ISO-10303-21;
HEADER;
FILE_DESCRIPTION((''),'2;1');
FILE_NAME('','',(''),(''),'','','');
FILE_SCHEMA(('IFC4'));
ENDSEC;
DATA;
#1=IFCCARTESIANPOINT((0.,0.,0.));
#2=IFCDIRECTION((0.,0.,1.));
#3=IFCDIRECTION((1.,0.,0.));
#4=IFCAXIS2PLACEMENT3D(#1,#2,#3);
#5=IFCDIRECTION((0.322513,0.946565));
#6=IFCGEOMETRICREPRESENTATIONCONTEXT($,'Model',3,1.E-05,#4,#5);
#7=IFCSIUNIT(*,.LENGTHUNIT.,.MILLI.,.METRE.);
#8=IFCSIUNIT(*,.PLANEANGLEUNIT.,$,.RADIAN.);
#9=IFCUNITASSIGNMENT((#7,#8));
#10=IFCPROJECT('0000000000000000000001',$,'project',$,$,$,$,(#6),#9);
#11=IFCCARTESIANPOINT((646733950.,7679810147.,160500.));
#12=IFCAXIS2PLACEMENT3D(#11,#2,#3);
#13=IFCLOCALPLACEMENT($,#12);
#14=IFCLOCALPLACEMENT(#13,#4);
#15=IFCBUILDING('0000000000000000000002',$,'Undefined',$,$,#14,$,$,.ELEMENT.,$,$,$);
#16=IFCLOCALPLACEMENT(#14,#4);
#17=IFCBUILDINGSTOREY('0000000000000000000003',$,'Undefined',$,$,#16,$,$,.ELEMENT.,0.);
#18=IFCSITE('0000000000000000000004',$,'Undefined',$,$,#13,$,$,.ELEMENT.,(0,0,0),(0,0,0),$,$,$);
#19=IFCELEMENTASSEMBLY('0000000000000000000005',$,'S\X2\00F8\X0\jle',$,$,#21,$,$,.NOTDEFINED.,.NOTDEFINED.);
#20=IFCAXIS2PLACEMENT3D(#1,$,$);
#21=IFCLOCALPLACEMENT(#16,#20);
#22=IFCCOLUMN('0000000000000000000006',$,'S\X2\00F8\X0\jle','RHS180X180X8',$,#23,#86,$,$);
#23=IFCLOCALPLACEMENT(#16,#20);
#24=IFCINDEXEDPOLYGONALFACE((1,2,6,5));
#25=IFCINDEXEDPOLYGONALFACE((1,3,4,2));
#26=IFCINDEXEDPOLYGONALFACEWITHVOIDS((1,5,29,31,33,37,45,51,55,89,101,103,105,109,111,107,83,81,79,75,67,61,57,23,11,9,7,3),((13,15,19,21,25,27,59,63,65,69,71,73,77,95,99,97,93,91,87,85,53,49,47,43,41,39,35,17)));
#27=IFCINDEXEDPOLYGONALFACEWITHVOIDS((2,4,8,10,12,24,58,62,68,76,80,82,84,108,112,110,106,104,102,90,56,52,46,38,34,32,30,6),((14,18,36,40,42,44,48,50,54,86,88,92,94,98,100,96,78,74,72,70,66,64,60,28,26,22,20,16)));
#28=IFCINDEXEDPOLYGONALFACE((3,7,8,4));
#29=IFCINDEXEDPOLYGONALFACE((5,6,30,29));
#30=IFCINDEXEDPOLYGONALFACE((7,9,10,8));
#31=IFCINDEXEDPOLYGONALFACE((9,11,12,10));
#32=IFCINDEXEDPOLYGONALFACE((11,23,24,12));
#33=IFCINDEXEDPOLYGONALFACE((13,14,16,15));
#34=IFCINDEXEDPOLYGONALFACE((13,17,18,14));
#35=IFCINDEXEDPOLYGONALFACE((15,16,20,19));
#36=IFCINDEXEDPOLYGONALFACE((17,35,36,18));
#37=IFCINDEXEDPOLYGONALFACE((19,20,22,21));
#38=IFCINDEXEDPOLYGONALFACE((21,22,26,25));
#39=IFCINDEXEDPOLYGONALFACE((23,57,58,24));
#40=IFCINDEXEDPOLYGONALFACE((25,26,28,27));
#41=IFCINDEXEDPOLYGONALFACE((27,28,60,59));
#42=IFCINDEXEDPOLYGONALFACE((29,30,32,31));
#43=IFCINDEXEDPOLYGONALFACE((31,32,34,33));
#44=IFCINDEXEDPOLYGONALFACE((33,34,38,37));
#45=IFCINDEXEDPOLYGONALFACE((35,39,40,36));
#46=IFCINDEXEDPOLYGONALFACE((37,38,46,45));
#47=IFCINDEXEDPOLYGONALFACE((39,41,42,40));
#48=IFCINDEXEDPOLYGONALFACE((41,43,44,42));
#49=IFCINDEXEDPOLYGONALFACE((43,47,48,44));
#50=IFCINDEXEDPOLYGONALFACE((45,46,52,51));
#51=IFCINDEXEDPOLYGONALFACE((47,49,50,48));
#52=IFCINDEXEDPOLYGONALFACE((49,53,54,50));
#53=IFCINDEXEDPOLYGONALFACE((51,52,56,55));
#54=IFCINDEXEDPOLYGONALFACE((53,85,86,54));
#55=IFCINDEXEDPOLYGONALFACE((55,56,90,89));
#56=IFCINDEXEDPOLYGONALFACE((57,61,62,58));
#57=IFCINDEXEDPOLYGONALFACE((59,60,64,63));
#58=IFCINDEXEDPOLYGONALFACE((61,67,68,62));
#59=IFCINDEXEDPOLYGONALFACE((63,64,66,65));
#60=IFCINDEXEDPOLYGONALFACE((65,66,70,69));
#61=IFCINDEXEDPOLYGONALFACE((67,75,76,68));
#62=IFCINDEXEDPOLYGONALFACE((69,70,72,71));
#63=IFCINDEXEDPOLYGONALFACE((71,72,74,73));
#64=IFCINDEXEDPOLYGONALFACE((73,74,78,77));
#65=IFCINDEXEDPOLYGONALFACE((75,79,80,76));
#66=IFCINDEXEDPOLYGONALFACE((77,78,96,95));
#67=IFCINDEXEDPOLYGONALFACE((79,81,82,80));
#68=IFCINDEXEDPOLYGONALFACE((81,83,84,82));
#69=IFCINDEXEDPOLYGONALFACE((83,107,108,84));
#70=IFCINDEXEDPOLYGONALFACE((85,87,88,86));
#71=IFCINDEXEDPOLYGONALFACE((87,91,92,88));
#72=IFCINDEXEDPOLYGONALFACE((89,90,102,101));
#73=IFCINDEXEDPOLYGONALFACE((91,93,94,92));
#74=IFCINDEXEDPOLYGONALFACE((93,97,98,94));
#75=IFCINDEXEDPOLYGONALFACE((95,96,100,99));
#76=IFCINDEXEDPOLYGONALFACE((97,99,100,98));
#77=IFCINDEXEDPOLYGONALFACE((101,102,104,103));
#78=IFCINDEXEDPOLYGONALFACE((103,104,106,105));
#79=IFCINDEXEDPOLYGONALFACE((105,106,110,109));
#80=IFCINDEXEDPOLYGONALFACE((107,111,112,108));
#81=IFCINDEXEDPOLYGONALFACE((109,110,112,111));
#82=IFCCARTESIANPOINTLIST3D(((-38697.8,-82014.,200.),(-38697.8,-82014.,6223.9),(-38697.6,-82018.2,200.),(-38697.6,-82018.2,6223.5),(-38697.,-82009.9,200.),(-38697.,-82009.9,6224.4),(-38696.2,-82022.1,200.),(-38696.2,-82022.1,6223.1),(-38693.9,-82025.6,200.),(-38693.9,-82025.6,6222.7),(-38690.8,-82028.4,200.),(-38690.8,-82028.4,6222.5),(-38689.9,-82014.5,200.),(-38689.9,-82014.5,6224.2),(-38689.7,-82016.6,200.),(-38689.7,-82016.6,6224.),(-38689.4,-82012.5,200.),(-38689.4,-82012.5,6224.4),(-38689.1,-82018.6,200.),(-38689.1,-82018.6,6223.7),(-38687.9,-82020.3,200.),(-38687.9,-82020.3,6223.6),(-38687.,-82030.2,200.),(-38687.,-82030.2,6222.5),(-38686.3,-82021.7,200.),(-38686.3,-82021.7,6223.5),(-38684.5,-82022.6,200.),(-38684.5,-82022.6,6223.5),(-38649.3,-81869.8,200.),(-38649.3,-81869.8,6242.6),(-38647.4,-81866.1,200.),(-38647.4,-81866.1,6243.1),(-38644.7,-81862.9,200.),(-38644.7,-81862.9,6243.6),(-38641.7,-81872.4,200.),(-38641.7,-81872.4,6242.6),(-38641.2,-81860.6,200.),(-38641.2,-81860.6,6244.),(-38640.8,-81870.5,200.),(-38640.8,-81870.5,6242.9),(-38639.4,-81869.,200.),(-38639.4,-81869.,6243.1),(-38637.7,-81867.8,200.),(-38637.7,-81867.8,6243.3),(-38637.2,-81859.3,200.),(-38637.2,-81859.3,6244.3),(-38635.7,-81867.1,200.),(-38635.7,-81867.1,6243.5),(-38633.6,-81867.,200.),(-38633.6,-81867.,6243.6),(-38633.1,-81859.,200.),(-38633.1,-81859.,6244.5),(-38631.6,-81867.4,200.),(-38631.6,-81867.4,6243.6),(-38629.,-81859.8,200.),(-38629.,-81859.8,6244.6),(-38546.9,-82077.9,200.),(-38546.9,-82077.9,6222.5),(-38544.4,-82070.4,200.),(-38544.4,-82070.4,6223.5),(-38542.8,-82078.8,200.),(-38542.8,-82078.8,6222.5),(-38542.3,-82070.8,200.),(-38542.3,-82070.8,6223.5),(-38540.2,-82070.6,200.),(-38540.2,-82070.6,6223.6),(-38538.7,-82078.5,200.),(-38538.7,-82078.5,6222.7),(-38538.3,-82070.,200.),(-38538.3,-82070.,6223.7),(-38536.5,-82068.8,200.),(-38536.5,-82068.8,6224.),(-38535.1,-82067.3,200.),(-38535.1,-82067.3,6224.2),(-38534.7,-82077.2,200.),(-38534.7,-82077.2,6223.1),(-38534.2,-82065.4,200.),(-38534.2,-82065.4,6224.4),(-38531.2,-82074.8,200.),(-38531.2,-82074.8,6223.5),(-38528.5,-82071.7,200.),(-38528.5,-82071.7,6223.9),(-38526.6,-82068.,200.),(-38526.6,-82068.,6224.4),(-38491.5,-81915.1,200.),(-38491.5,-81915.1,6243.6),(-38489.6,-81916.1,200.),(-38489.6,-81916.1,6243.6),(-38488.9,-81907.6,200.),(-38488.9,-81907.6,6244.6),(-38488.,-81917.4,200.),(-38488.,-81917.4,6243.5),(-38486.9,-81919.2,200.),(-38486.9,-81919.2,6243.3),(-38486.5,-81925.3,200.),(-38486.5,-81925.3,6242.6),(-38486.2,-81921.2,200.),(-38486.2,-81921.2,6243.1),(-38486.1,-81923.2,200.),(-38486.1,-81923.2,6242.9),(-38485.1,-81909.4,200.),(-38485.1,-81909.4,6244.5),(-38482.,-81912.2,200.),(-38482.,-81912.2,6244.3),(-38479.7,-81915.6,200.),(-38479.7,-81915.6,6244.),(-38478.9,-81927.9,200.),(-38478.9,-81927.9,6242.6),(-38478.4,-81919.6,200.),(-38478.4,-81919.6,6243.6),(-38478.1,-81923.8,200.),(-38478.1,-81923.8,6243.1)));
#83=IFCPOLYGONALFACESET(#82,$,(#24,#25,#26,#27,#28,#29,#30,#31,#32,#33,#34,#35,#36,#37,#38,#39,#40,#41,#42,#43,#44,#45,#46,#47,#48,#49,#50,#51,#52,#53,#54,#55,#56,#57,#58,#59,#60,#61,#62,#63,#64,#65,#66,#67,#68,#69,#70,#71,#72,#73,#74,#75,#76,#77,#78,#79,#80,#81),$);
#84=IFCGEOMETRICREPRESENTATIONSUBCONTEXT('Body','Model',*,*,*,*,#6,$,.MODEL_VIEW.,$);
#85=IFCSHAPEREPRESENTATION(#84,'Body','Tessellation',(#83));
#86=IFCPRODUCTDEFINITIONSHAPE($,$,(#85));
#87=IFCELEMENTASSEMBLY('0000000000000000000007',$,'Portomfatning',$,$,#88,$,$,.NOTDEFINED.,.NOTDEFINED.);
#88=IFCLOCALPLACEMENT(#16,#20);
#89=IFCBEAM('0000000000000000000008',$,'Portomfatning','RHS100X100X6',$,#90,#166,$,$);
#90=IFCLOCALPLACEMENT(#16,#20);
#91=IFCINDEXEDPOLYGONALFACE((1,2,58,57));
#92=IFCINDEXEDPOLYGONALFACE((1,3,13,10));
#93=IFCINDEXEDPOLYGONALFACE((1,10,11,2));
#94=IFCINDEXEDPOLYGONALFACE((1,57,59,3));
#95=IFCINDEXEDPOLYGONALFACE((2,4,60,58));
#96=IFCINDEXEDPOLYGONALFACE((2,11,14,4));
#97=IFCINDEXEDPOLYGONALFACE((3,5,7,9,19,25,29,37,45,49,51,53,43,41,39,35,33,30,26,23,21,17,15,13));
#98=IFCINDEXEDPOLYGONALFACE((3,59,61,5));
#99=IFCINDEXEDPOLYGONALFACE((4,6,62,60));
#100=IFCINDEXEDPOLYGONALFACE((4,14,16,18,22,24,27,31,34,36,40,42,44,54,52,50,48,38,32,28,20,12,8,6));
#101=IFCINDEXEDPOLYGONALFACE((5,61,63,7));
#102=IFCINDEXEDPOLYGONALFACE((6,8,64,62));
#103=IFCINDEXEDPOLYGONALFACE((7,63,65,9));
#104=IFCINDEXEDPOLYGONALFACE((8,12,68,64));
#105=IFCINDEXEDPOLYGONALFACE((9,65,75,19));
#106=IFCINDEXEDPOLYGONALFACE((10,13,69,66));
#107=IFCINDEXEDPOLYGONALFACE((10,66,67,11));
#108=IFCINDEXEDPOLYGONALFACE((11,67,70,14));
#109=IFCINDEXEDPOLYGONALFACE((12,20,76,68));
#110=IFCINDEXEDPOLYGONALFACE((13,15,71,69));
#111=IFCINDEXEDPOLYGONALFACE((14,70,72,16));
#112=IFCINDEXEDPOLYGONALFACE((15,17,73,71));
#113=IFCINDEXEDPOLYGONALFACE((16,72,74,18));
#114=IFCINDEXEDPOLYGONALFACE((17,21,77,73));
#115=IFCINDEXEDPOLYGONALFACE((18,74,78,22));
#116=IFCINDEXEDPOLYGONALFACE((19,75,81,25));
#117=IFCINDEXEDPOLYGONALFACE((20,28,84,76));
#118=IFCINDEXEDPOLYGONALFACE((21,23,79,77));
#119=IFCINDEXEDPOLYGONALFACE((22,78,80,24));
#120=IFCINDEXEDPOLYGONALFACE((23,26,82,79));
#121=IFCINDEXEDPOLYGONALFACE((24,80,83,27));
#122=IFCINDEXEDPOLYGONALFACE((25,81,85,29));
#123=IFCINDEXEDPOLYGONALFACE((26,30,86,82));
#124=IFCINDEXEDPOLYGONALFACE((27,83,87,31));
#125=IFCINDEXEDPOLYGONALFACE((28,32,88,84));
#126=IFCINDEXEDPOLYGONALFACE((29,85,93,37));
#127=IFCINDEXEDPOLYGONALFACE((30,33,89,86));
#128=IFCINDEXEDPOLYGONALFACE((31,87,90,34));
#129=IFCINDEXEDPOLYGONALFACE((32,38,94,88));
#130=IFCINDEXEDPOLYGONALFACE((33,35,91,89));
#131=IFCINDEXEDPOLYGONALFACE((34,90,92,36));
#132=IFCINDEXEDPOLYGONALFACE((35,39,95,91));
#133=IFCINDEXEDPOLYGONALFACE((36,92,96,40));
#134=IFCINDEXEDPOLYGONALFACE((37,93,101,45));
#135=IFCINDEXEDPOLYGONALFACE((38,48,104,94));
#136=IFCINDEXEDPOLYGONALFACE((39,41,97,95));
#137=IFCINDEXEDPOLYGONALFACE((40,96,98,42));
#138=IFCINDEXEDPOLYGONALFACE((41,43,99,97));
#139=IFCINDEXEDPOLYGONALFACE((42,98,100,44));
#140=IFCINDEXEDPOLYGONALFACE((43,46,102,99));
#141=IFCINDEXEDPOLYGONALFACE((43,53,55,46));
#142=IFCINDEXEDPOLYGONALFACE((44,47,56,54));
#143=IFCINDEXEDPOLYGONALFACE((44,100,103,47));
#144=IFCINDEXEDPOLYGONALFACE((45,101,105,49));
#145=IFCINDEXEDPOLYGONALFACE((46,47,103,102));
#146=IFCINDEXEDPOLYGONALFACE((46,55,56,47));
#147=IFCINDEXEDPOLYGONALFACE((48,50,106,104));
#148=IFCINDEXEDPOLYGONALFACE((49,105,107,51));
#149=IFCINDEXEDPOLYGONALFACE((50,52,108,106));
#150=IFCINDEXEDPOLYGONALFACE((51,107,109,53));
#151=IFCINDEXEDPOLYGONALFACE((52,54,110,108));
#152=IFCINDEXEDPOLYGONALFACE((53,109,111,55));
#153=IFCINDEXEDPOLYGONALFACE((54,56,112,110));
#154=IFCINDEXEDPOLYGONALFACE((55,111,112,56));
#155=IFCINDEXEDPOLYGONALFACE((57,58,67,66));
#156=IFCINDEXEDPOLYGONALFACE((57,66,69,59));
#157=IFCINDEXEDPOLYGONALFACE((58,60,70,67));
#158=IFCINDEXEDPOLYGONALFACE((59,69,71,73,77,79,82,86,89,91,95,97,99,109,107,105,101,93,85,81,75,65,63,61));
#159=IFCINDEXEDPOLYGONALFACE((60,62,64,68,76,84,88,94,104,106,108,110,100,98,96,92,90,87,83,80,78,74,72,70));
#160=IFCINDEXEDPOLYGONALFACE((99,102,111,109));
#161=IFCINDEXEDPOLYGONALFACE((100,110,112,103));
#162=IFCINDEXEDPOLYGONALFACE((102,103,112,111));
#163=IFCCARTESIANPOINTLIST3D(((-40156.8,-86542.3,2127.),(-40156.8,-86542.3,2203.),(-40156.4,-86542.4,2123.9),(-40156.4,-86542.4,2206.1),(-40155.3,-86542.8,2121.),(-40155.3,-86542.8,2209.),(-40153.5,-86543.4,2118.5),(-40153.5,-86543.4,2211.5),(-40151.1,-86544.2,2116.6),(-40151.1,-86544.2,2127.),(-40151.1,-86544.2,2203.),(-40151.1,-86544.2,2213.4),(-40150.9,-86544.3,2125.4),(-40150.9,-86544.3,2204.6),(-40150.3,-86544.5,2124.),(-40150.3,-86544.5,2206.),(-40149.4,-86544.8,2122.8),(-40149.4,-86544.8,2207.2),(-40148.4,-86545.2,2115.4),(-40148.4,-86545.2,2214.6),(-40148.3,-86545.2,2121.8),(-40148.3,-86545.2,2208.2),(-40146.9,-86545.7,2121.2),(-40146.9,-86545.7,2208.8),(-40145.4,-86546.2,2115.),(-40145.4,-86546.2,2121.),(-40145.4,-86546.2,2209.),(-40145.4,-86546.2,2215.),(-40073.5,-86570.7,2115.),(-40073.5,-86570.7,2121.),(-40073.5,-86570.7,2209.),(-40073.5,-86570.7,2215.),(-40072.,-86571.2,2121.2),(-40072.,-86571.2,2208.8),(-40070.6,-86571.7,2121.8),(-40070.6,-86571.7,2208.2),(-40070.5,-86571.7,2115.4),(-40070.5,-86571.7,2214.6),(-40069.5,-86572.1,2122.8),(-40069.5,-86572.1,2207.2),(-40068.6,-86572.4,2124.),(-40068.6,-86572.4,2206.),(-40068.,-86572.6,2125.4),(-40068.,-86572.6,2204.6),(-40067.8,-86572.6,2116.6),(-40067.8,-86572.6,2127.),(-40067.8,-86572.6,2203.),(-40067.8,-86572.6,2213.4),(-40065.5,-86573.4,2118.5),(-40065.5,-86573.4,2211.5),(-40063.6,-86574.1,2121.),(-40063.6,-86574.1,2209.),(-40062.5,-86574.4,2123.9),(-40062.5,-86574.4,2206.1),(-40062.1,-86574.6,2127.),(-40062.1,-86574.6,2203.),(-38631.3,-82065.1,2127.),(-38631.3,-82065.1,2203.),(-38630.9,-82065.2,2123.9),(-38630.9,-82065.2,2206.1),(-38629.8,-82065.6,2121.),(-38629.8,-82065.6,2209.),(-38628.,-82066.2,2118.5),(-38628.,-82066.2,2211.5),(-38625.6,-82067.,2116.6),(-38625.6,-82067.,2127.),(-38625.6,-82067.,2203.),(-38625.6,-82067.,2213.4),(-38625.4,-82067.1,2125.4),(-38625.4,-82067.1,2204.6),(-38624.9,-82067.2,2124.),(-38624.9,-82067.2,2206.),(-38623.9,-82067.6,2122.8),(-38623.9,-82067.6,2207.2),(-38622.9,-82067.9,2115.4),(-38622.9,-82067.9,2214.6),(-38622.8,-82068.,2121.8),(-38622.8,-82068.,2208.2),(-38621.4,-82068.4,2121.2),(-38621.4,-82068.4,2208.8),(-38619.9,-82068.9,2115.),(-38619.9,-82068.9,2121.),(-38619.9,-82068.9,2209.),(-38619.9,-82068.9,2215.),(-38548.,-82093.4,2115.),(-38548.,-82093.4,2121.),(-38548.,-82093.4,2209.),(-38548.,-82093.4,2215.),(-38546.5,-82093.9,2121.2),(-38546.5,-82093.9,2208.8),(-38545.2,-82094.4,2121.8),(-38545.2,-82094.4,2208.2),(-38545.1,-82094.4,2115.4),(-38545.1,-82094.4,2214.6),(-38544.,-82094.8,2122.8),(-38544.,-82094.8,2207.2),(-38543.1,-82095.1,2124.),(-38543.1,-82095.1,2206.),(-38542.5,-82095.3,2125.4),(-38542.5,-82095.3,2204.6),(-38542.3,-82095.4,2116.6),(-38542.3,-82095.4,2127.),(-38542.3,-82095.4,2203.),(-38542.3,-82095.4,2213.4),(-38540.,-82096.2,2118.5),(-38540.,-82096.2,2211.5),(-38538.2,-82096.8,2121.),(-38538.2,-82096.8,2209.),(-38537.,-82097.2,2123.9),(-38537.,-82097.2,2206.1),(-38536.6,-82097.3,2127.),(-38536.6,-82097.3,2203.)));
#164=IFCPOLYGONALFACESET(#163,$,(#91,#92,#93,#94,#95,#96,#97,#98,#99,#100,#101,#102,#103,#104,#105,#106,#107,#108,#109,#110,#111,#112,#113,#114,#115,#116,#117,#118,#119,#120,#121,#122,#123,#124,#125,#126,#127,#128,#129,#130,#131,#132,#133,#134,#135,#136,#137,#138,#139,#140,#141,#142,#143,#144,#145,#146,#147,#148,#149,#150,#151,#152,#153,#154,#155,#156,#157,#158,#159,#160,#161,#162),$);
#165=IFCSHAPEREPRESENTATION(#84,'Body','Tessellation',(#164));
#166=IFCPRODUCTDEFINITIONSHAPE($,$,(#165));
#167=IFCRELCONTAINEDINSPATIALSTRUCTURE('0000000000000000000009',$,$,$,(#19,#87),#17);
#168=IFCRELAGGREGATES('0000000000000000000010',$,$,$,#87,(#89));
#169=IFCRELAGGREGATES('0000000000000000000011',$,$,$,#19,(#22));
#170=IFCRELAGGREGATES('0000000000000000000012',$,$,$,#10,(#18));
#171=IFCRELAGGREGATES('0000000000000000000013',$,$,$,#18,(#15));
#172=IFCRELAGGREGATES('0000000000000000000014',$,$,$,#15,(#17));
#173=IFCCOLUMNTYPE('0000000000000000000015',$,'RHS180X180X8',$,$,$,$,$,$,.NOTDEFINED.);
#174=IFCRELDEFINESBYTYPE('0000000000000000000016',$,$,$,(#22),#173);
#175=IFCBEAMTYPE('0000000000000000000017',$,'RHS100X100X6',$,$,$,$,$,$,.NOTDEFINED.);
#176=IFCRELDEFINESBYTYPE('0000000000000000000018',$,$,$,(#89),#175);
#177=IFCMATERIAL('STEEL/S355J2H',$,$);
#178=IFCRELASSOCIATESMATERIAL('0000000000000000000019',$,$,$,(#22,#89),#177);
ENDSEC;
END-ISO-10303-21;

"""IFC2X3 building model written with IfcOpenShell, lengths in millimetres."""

from ifc_helpers import new_model, si_unit, direction, frame, origin_with_axes, origin_2d_with_axis, place, context, subcontext, project, spatial, hollow_rectangle, extrude, clip, halfspace, material, type_object, element, aggregate, save


model = new_model("IFC2X3")

# Units and contexts
model_context = context("Model", 3, precision=1e-05, world=origin_with_axes(), true_north=direction((0.322513, 0.946565)))
body_context = subcontext(model_context, "Body", "Model", "MODEL_VIEW")
ifc_project = project(units=[si_unit("LENGTHUNIT", "METRE", prefix="MILLI"), si_unit("PLANEANGLEUNIT", "RADIAN")], contexts=[model_context])

# Site, building, storey
site_placement = place(None, frame((646733950.0, 7679810147.0, 160500.0), z_axis=(0.0, 0.0, 1.0), x_axis=(1.0, 0.0, 0.0)))
site = spatial("IfcSite", under=ifc_project, at=site_placement, Name="Undefined", CompositionType="ELEMENT", RefLatitude=(0, 0, 0), RefLongitude=(0, 0, 0))
building_placement = place(site_placement, origin_with_axes())
building = spatial("IfcBuilding", under=site, at=building_placement, Name="Undefined", CompositionType="ELEMENT")
storey_placement = place(building_placement, origin_with_axes())
storey = spatial("IfcBuildingStorey", under=building, at=storey_placement, Name="Undefined", CompositionType="ELEMENT", Elevation=0.0)

# Shared definitions
ifc_material_1 = material(Name="STEEL/S355J2H")

# Element assembly, column
assembly_1_placement = place(storey_placement, origin_with_axes())
assembly_1 = element("IfcElementAssembly", 1, at=assembly_1_placement, inside=storey, Name="Søjle", AssemblyPlace="NOTDEFINED", PredefinedType="NOTDEFINED")
column_type_1 = type_object("IfcColumnType", Name="RHS180X180X8", PredefinedType="NOTDEFINED")
column_1_placement = place(assembly_1_placement, frame((-38588.0, -81968.9, 200.0), z_axis=(0.0, 0.0, 1.0), x_axis=(0.322513, 0.946565, 0.0)))
column_1 = element("IfcColumn", 2, at=column_1_placement, type_object=column_type_1, material=ifc_material_1, Name="Søjle", Description="RHS180X180X8", context=body_context, shape_type="Clipping", body=[
    clip(extrude(hollow_rectangle(XDim=180.0, YDim=180.0, WallThickness=8.0, InnerFilletRadius=8.0, OuterFilletRadius=16.0, at=origin_2d_with_axis()), frame((0.0, 0.0, 6044.7), z_axis=(0.0, 0.0, -1.0), x_axis=(0.0, 1.0, 0.0)), (0.0, 0.0, 1.0), 6044.7), halfspace(frame((-90.0, 0.0, 6022.5), z_axis=(0.121869, 0.0, -0.992546), x_axis=(0.0, -1.0, 0.0)), True)),
])

# Element assembly, beam
assembly_2_placement = place(storey_placement, origin_with_axes())
assembly_2 = element("IfcElementAssembly", 3, at=assembly_2_placement, inside=storey, Name="Portomfatning", AssemblyPlace="NOTDEFINED", PredefinedType="NOTDEFINED")
beam_type_1 = type_object("IfcBeamType", Name="RHS100X100X6", PredefinedType="NOTDEFINED")
beam_1_placement = place(assembly_2_placement, frame((-38579.1, -82067.0, 2165.0), z_axis=(0.946565, -0.322513, 0.0), x_axis=(-0.322513, -0.946565, 0.0)))
beam_1 = element("IfcBeam", 4, at=beam_1_placement, type_object=beam_type_1, material=ifc_material_1, Name="Portomfatning", Description="RHS100X100X6", context=body_context, shape_type="Clipping", body=[
    clip(clip(extrude(hollow_rectangle(XDim=100.0, YDim=100.0, WallThickness=6.0, InnerFilletRadius=6.0, OuterFilletRadius=12.0, at=origin_2d_with_axis()), frame((4806.7, 0.0, 0.0), z_axis=(-1.0, 0.0, 0.0), x_axis=(0.0, -1.0, 0.0)), (0.0, 0.0, 1.0), 4853.4), halfspace(frame((4745.0, -50.0, -50.0), z_axis=(-1.0, 0.0, 0.000185), x_axis=(0.0, 1.0, 0.0)), True)), halfspace(frame((15.0, 50.0, -50.0), z_axis=(1.0, 0.0, 0.000185), x_axis=(0.0, -1.0, 0.0)), True)),
])
aggregate(assembly_2, [beam_1])

aggregate(assembly_1, [column_1])

save(model, "model.ifc")
